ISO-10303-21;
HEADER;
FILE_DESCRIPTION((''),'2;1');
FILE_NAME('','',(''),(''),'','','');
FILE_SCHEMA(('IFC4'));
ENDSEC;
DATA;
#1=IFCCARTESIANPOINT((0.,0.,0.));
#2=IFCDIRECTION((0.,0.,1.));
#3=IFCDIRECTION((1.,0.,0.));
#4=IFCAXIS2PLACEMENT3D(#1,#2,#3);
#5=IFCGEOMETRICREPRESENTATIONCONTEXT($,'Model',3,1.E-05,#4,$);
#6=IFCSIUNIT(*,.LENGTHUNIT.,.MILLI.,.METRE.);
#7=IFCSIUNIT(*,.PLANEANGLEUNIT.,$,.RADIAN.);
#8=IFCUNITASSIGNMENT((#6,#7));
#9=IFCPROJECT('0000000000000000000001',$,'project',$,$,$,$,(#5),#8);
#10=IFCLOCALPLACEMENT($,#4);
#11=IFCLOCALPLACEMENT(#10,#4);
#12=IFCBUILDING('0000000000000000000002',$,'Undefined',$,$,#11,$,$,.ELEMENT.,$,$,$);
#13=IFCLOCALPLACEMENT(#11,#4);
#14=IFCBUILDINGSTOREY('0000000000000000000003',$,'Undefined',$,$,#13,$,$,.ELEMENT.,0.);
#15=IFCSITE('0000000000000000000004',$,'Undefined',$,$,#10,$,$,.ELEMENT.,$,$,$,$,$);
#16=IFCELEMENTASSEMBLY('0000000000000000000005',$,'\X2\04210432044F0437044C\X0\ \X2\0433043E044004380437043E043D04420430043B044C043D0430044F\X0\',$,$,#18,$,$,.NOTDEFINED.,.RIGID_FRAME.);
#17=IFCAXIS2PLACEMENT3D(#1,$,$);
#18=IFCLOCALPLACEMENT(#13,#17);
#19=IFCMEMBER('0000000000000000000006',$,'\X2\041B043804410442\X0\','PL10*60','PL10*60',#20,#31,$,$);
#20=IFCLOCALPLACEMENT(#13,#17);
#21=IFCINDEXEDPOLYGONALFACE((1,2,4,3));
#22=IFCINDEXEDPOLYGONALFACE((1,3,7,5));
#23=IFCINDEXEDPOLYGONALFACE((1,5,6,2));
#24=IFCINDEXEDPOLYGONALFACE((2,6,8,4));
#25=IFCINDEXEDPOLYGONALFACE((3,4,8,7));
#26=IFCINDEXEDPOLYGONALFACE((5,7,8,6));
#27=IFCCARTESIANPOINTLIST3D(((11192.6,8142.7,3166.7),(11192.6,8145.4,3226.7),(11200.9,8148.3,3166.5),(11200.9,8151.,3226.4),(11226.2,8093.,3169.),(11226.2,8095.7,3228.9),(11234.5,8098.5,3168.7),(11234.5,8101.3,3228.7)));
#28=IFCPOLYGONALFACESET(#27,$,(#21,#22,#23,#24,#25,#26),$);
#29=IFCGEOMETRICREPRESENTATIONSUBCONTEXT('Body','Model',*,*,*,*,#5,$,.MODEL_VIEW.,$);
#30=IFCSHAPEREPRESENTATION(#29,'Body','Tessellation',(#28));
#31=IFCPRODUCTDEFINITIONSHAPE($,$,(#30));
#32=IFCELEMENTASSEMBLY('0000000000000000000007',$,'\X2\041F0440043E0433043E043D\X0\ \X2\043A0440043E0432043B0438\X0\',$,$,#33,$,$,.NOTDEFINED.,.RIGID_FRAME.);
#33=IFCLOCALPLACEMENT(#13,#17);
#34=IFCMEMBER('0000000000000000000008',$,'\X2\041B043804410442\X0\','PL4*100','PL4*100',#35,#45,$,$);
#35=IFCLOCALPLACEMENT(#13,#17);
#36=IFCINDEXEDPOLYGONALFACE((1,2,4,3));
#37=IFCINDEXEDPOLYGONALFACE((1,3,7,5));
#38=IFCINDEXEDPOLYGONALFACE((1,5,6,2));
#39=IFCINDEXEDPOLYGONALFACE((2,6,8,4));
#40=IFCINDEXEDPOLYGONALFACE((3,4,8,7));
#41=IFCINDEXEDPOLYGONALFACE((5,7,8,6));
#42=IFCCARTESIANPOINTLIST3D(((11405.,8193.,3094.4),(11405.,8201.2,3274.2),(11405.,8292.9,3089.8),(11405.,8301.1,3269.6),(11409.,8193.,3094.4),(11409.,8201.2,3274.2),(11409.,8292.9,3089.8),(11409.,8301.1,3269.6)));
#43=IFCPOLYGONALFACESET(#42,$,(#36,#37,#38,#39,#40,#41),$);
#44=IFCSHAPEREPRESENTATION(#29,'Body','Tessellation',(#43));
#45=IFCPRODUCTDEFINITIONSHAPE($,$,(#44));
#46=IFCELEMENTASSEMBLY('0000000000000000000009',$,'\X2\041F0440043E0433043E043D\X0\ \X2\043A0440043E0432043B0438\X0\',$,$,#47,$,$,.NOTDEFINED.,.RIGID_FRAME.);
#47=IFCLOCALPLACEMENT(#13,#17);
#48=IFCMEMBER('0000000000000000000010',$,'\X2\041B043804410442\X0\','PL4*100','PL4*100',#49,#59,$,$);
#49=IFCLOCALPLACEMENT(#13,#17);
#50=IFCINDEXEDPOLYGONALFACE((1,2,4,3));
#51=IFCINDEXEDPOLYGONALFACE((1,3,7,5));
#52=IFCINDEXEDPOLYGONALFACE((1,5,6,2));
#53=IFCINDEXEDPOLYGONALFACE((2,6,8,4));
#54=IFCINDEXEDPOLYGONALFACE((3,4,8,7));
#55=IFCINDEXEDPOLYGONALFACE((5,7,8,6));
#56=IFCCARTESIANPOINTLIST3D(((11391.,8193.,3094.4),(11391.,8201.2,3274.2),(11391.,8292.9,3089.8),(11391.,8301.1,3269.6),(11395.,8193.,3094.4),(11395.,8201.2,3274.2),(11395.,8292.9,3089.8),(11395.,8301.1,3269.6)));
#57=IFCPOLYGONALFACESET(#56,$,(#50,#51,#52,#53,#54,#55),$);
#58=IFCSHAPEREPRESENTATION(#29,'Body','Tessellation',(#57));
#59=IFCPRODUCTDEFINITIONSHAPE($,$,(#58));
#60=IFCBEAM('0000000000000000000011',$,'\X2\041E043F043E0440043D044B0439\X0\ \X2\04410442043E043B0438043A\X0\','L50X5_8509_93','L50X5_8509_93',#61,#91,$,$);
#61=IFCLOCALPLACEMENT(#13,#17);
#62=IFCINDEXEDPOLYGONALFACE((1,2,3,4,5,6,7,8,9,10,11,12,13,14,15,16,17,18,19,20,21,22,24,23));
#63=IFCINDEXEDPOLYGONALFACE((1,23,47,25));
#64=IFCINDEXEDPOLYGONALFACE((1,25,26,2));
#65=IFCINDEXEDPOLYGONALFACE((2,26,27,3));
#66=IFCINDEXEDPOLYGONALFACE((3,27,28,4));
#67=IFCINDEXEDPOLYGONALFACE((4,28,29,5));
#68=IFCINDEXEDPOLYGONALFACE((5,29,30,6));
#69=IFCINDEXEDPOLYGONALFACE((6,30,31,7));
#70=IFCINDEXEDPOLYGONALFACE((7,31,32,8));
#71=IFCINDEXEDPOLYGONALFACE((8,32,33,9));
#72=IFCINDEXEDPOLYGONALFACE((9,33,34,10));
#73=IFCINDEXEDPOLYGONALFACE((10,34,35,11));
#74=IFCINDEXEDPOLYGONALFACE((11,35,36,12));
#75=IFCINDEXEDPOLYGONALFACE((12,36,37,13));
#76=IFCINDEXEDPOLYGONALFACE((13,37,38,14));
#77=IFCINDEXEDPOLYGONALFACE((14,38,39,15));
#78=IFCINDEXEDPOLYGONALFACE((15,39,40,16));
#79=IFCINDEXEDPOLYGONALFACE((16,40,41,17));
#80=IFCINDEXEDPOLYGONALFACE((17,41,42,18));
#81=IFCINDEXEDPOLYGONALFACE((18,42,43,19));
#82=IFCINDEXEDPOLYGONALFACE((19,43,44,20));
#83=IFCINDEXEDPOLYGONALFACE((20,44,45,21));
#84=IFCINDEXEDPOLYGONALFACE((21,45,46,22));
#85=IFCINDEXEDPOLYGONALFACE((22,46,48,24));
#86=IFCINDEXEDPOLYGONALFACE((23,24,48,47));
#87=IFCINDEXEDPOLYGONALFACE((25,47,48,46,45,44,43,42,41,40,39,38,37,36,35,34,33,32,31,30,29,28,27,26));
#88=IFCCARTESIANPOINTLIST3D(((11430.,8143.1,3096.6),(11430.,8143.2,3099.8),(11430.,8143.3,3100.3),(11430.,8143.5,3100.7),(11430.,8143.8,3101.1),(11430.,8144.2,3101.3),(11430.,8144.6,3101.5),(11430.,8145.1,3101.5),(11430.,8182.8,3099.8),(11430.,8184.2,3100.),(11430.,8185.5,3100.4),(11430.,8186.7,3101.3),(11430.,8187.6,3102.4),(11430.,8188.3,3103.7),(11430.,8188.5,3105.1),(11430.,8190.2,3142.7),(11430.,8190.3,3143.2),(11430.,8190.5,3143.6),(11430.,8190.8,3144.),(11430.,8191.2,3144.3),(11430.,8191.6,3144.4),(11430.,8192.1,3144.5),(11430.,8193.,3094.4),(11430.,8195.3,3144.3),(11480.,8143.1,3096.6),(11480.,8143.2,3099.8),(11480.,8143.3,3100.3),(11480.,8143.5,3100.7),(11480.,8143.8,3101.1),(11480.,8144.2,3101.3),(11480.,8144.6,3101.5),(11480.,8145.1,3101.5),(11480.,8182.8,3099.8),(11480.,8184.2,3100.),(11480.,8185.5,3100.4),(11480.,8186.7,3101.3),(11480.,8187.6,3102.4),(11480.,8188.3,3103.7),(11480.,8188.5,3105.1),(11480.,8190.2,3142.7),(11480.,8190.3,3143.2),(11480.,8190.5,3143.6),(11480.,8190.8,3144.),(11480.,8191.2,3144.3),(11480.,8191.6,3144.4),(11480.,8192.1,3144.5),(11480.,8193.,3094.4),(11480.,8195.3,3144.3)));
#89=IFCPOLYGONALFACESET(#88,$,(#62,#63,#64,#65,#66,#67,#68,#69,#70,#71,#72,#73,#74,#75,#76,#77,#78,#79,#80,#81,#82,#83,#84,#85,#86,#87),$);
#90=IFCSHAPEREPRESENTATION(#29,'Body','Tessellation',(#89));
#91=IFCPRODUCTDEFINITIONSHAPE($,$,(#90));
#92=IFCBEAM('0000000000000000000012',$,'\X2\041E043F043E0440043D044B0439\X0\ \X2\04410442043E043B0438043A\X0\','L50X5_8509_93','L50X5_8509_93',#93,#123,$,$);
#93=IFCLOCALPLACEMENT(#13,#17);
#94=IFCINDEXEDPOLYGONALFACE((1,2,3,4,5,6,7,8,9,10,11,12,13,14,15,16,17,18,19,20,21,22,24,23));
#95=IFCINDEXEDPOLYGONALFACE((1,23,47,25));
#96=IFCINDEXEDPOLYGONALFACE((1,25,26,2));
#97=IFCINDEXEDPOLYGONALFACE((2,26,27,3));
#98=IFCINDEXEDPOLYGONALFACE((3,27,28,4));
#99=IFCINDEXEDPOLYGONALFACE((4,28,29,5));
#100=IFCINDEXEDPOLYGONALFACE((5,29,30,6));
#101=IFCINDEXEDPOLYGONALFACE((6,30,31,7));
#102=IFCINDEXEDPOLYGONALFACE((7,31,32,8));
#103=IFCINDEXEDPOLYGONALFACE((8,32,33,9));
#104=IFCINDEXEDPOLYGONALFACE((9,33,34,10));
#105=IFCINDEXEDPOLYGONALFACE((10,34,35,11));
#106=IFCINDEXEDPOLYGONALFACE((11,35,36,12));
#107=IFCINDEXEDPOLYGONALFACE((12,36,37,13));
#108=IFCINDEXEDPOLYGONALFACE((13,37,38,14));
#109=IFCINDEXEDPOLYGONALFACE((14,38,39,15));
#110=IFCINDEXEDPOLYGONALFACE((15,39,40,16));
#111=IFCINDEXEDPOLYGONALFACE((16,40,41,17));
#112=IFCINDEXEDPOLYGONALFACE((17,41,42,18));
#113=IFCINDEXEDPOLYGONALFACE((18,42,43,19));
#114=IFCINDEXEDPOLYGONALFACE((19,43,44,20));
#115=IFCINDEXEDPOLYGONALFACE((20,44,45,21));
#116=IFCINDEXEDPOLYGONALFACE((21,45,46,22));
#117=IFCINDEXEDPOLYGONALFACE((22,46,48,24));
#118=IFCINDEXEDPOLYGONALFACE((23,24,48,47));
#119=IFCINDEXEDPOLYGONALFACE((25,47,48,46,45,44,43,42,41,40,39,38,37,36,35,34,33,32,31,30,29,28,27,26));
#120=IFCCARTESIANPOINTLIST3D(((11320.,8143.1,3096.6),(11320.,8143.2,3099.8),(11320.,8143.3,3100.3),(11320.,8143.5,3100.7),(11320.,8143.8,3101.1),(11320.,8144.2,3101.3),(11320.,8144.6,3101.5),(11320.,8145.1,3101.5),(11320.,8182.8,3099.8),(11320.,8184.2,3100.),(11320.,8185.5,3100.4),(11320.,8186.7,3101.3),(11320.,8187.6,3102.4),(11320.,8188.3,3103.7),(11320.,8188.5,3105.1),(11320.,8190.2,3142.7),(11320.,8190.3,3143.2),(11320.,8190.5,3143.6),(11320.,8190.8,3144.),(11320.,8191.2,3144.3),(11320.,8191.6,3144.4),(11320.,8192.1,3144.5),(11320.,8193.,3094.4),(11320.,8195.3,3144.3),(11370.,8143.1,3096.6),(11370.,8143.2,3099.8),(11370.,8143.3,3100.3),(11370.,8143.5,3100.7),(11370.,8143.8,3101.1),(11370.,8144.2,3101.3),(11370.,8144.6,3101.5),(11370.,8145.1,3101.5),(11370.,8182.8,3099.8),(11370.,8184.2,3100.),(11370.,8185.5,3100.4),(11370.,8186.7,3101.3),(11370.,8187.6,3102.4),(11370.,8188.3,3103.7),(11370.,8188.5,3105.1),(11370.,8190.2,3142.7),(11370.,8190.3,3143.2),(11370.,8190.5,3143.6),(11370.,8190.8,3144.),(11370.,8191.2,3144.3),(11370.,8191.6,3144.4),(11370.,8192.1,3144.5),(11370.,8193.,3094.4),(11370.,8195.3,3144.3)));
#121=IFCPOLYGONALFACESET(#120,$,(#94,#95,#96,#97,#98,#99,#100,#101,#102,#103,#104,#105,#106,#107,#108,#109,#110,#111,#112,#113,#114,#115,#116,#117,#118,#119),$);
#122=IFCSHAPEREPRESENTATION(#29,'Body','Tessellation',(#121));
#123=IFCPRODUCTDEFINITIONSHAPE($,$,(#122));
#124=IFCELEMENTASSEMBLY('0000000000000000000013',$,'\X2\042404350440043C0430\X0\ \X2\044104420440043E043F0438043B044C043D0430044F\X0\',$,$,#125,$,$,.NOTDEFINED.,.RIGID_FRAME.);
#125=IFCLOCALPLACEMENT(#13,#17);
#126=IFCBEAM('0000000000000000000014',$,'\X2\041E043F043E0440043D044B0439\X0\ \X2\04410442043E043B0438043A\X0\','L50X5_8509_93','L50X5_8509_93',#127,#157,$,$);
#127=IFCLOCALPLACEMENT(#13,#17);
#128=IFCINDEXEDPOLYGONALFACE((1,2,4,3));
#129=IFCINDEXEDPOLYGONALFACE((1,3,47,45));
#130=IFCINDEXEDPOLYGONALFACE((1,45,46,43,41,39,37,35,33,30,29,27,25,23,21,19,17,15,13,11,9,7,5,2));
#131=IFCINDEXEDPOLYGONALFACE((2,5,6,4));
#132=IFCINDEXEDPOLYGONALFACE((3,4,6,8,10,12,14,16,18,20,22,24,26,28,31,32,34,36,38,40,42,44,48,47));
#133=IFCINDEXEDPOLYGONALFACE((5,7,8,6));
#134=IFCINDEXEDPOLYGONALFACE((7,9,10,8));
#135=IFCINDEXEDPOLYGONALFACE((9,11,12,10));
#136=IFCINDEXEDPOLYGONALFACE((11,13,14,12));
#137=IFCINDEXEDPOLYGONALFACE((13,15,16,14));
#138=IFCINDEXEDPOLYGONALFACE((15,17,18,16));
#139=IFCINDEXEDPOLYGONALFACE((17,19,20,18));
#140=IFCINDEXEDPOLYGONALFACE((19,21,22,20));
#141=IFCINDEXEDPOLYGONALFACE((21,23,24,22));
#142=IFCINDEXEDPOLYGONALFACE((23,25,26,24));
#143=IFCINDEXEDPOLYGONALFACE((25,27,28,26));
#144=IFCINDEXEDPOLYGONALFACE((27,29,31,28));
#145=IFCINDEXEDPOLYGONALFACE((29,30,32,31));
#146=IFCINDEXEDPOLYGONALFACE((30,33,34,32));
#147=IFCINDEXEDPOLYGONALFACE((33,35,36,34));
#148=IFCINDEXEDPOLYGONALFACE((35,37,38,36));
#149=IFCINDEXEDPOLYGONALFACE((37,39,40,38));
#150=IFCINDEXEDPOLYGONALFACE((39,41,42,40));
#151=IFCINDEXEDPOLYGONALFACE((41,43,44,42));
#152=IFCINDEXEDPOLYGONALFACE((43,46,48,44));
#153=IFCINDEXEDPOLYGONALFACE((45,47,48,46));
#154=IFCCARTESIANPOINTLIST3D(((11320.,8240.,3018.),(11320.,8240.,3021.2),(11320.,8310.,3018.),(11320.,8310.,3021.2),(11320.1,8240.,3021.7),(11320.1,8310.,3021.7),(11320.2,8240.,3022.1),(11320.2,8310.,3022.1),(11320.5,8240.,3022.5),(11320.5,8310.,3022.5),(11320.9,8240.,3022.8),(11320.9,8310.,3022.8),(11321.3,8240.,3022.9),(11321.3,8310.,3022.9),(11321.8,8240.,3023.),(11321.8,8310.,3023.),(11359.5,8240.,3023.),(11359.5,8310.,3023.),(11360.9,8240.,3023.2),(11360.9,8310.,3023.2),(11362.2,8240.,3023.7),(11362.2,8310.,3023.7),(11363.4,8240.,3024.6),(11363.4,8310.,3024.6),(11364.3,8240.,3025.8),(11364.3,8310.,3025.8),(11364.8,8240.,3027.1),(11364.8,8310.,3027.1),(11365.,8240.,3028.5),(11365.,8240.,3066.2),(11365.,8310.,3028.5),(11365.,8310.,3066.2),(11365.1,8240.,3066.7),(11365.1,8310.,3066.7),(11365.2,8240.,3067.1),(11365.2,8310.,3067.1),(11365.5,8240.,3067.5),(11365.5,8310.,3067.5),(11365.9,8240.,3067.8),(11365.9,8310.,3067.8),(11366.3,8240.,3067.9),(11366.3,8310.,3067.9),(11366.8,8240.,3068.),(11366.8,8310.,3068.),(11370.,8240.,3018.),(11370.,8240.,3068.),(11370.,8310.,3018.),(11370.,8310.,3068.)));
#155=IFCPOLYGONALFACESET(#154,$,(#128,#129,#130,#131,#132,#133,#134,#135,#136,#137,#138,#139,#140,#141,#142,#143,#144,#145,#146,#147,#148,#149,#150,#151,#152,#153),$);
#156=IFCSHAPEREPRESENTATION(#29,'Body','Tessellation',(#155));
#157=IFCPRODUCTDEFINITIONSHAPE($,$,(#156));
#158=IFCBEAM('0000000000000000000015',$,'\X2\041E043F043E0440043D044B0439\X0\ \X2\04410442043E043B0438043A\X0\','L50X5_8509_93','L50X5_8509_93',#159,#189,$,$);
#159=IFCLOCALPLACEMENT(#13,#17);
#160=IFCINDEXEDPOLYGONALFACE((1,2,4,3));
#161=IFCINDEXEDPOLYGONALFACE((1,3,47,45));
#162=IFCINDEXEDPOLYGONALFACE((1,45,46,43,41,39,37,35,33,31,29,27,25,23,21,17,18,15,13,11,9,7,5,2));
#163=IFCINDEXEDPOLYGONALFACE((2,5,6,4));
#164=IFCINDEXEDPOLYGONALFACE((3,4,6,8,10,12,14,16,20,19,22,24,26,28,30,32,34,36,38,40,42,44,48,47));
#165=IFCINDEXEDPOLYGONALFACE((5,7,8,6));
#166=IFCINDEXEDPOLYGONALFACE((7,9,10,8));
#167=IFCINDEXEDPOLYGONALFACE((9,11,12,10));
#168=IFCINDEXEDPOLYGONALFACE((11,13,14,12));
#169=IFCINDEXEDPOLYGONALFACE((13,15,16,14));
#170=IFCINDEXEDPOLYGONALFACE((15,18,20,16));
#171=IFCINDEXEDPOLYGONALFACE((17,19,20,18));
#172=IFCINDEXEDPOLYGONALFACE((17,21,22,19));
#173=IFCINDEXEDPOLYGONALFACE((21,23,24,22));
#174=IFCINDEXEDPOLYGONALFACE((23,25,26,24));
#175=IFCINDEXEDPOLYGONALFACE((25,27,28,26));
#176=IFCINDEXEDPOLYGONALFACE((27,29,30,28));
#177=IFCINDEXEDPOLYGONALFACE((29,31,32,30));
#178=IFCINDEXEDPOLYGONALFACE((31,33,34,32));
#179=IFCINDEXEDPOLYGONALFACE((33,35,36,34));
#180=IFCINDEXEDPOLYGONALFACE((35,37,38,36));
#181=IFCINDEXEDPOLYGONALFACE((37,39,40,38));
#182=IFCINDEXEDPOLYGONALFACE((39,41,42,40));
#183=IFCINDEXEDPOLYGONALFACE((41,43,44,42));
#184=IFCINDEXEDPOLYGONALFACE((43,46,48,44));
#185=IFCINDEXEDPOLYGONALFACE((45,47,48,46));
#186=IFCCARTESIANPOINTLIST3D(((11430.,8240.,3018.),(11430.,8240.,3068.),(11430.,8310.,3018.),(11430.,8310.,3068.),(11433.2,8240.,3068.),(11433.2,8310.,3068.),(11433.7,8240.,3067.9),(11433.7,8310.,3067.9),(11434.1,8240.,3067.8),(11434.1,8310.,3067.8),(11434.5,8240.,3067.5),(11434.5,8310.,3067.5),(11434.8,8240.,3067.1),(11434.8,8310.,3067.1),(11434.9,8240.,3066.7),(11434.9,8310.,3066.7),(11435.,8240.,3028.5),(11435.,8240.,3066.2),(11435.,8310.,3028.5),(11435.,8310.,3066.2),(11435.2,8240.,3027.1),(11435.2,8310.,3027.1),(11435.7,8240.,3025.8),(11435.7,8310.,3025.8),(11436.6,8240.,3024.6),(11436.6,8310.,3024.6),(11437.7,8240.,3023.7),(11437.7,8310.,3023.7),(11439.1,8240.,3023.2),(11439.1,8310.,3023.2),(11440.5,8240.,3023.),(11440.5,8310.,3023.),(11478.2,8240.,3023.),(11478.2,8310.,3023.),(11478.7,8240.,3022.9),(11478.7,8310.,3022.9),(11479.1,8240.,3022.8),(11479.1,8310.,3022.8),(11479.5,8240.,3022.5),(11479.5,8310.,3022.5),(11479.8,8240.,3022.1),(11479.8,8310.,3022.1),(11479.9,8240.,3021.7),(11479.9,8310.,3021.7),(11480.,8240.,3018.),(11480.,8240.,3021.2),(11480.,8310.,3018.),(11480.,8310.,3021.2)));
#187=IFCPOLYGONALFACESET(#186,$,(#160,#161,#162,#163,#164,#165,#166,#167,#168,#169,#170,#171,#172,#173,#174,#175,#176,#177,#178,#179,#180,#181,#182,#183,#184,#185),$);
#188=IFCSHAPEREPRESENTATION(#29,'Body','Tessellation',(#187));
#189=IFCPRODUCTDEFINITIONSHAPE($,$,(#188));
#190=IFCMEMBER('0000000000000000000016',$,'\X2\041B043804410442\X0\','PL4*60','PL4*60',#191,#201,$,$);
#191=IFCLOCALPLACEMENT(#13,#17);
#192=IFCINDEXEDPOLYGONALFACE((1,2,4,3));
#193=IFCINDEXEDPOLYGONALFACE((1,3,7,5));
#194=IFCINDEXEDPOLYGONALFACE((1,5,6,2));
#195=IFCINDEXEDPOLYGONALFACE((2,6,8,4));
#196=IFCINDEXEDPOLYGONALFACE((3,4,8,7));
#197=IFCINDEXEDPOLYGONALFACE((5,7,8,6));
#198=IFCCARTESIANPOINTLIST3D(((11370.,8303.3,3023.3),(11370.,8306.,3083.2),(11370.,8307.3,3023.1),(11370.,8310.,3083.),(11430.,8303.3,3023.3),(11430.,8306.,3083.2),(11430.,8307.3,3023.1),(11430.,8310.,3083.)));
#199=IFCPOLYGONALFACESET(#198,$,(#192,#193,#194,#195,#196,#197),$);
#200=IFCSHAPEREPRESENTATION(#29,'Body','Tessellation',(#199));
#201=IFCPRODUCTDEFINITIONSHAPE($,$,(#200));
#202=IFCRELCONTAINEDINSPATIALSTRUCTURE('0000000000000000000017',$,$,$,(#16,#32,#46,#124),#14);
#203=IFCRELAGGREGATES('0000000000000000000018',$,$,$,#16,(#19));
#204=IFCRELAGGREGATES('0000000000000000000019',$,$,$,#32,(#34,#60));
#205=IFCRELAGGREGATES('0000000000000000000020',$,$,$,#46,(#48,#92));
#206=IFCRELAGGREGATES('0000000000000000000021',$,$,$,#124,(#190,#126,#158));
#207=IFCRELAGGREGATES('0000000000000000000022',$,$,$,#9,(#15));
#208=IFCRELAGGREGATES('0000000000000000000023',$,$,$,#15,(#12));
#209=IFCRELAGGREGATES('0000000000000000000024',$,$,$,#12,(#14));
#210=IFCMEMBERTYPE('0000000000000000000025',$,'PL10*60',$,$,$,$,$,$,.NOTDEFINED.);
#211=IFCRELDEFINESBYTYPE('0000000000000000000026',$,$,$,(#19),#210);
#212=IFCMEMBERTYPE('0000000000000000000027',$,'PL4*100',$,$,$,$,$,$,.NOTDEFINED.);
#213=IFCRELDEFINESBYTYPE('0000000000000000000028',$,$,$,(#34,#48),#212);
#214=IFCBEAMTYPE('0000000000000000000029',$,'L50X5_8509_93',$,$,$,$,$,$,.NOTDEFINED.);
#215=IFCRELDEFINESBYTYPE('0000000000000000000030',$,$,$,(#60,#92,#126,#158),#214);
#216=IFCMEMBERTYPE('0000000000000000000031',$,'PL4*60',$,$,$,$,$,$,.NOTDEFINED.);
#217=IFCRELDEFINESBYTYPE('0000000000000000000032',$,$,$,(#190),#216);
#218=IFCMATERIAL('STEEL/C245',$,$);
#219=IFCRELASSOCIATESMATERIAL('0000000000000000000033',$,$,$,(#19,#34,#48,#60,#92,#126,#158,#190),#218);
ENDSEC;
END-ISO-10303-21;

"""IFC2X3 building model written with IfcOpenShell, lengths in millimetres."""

from ifc_helpers import new_model, si_unit, frame, origin_with_axes, origin_2d_with_axis, place, context, subcontext, project, spatial, rectangle, l_section, extrude, material, type_object, element, aggregate, save


model = new_model("IFC2X3")

# Units and contexts
model_context = context("Model", 3, precision=1e-05, world=origin_with_axes())
body_context = subcontext(model_context, "Body", "Model", "MODEL_VIEW")
ifc_project = project(units=[si_unit("LENGTHUNIT", "METRE", prefix="MILLI"), si_unit("PLANEANGLEUNIT", "RADIAN")], contexts=[model_context])

# Site, building, storey
site_placement = place(None, origin_with_axes())
site = spatial("IfcSite", under=ifc_project, at=site_placement, Name="Undefined", CompositionType="ELEMENT")
building_placement = place(site_placement, origin_with_axes())
building = spatial("IfcBuilding", under=site, at=building_placement, Name="Undefined", CompositionType="ELEMENT")
storey_placement = place(building_placement, origin_with_axes())
storey = spatial("IfcBuildingStorey", under=building, at=storey_placement, Name="Undefined", CompositionType="ELEMENT", Elevation=0.0)

# Shared definitions
ifc_material_1 = material(Name="STEEL/C245")

# Element assembly, member
member_type_1 = type_object("IfcMemberType", Name="PL10*60", PredefinedType="NOTDEFINED")
assembly_1_placement = place(storey_placement, origin_with_axes())
assembly_1 = element("IfcElementAssembly", 1, at=assembly_1_placement, inside=storey, Name="Связь горизонтальная", AssemblyPlace="NOTDEFINED", PredefinedType="RIGID_FRAME")
member_1_placement = place(assembly_1_placement, frame((11213.5, 8120.6, 3167.7), z_axis=(0.558918, -0.828367, 0.037653), x_axis=(0.0, 0.045408, 0.998969)))
member_1 = element("IfcMember", 2, at=member_1_placement, type_object=member_type_1, material=ifc_material_1, Name="Лист", Description="PL10*60", ObjectType="PL10*60", context=body_context, shape_type="SweptSolid", body=[
    extrude(rectangle(XDim=10.0, YDim=60.0, at=origin_2d_with_axis()), frame((60.0, 0.0, 0.0), z_axis=(-1.0, 0.0, 0.0), x_axis=(0.0, -1.0, 0.0)), (0.0, 0.0, 1.0), 60.0),
])

# Element assemblies, members
assembly_2_placement = place(storey_placement, origin_with_axes())
assembly_2 = element("IfcElementAssembly", 3, at=assembly_2_placement, inside=storey, Name="Прогон кровли", AssemblyPlace="NOTDEFINED", PredefinedType="RIGID_FRAME")
member_type_2 = type_object("IfcMemberType", Name="PL4*100", PredefinedType="NOTDEFINED")
member_2_placement = place(assembly_2_placement, frame((11407.0, 8243.0, 3092.1), z_axis=(0.0, -0.998969, 0.045408), x_axis=(0.0, 0.045408, 0.998969)))
member_2 = element("IfcMember", 4, at=member_2_placement, type_object=member_type_2, material=ifc_material_1, Name="Лист", Description="PL4*100", ObjectType="PL4*100", context=body_context, shape_type="SweptSolid", body=[
    extrude(rectangle(XDim=4.0, YDim=100.0, at=origin_2d_with_axis()), frame((180.0, 0.0, 0.0), z_axis=(-1.0, 0.0, 0.0), x_axis=(0.0, -1.0, 0.0)), (0.0, 0.0, 1.0), 180.0),
])
assembly_3_placement = place(storey_placement, origin_with_axes())
assembly_3 = element("IfcElementAssembly", 5, at=assembly_3_placement, inside=storey, Name="Прогон кровли", AssemblyPlace="NOTDEFINED", PredefinedType="RIGID_FRAME")
member_3_placement = place(assembly_3_placement, frame((11393.0, 8243.0, 3092.1), z_axis=(0.0, 0.998969, -0.045408), x_axis=(0.0, 0.045408, 0.998969)))
member_3 = element("IfcMember", 6, at=member_3_placement, type_object=member_type_2, material=ifc_material_1, Name="Лист", Description="PL4*100", ObjectType="PL4*100", context=body_context, shape_type="SweptSolid", body=[
    extrude(rectangle(XDim=4.0, YDim=100.0, at=origin_2d_with_axis()), frame((180.0, 0.0, 0.0), z_axis=(-1.0, 0.0, 0.0), x_axis=(0.0, -1.0, 0.0)), (0.0, 0.0, 1.0), 180.0),
])

# Beams
beam_type_1 = type_object("IfcBeamType", Name="L50X5_8509_93", PredefinedType="NOTDEFINED")
beam_1_placement = place(assembly_2_placement, frame((11480.0, 8169.2, 3120.5), z_axis=(0.0, -0.998969, 0.045408), x_axis=(-1.0, 0.0, 0.0)))
beam_1 = element("IfcBeam", 7, at=beam_1_placement, type_object=beam_type_1, material=ifc_material_1, Name="Опорный столик", Description="L50X5_8509_93", ObjectType="L50X5_8509_93", context=body_context, shape_type="SweptSolid", body=[
    extrude(l_section(Depth=50.0, Width=50.0, Thickness=5.0, FilletRadius=5.5, EdgeRadius=1.8, at=origin_2d_with_axis()), frame((50.0, 0.0, 0.0), z_axis=(-1.0, 0.0, 0.0), x_axis=(0.0, -1.0, 0.0)), (0.0, 0.0, 1.0), 50.0),
])
beam_2_placement = place(assembly_3_placement, frame((11370.0, 8169.2, 3120.5), z_axis=(0.0, -0.998969, 0.045408), x_axis=(-1.0, 0.0, 0.0)))
beam_2 = element("IfcBeam", 8, at=beam_2_placement, type_object=beam_type_1, material=ifc_material_1, Name="Опорный столик", Description="L50X5_8509_93", ObjectType="L50X5_8509_93", context=body_context, shape_type="SweptSolid", body=[
    extrude(l_section(Depth=50.0, Width=50.0, Thickness=5.0, FilletRadius=5.5, EdgeRadius=1.8, at=origin_2d_with_axis()), frame((50.0, 0.0, 0.0), z_axis=(-1.0, 0.0, 0.0), x_axis=(0.0, -1.0, 0.0)), (0.0, 0.0, 1.0), 50.0),
])

# Element assembly, beams, member
assembly_4_placement = place(storey_placement, origin_with_axes())
assembly_4 = element("IfcElementAssembly", 9, at=assembly_4_placement, inside=storey, Name="Ферма стропильная", AssemblyPlace="NOTDEFINED", PredefinedType="RIGID_FRAME")
beam_3_placement = place(assembly_4_placement, frame((11345.0, 8240.0, 3043.0), z_axis=(-1.0, 0.0, 0.0), x_axis=(0.0, 1.0, 0.0)))
beam_3 = element("IfcBeam", 10, at=beam_3_placement, type_object=beam_type_1, material=ifc_material_1, Name="Опорный столик", Description="L50X5_8509_93", ObjectType="L50X5_8509_93", context=body_context, shape_type="SweptSolid", body=[
    extrude(l_section(Depth=50.0, Width=50.0, Thickness=5.0, FilletRadius=5.5, EdgeRadius=1.8, at=origin_2d_with_axis()), frame((70.0, 0.0, 0.0), z_axis=(-1.0, 0.0, 0.0), x_axis=(0.0, -1.0, 0.0)), (0.0, 0.0, 1.0), 70.0),
])
beam_4_placement = place(assembly_4_placement, frame((11455.0, 8310.0, 3043.0), z_axis=(1.0, 0.0, 0.0), x_axis=(0.0, -1.0, 0.0)))
beam_4 = element("IfcBeam", 11, at=beam_4_placement, type_object=beam_type_1, material=ifc_material_1, Name="Опорный столик", Description="L50X5_8509_93", ObjectType="L50X5_8509_93", context=body_context, shape_type="SweptSolid", body=[
    extrude(l_section(Depth=50.0, Width=50.0, Thickness=5.0, FilletRadius=5.5, EdgeRadius=1.8, at=origin_2d_with_axis()), frame((70.0, 0.0, 0.0), z_axis=(-1.0, 0.0, 0.0), x_axis=(0.0, -1.0, 0.0)), (0.0, 0.0, 1.0), 70.0),
])
member_type_3 = type_object("IfcMemberType", Name="PL4*60", PredefinedType="NOTDEFINED")
member_4_placement = place(assembly_4_placement, frame((11400.0, 8305.3, 3023.2), z_axis=(-1.0, 0.0, 0.0), x_axis=(0.0, 0.045408, 0.998969)))
member_4 = element("IfcMember", 12, at=member_4_placement, type_object=member_type_3, material=ifc_material_1, Name="Лист", Description="PL4*60", ObjectType="PL4*60", context=body_context, shape_type="SweptSolid", body=[
    extrude(rectangle(XDim=4.0, YDim=60.0, at=origin_2d_with_axis()), frame((60.0, 0.0, 0.0), z_axis=(-1.0, 0.0, 0.0), x_axis=(0.0, -1.0, 0.0)), (0.0, 0.0, 1.0), 60.0),
])

aggregate(assembly_1, [member_1])
aggregate(assembly_2, [member_2, beam_1])
aggregate(assembly_3, [member_3, beam_2])
aggregate(assembly_4, [member_4, beam_3, beam_4])

save(model, "model.ifc")
